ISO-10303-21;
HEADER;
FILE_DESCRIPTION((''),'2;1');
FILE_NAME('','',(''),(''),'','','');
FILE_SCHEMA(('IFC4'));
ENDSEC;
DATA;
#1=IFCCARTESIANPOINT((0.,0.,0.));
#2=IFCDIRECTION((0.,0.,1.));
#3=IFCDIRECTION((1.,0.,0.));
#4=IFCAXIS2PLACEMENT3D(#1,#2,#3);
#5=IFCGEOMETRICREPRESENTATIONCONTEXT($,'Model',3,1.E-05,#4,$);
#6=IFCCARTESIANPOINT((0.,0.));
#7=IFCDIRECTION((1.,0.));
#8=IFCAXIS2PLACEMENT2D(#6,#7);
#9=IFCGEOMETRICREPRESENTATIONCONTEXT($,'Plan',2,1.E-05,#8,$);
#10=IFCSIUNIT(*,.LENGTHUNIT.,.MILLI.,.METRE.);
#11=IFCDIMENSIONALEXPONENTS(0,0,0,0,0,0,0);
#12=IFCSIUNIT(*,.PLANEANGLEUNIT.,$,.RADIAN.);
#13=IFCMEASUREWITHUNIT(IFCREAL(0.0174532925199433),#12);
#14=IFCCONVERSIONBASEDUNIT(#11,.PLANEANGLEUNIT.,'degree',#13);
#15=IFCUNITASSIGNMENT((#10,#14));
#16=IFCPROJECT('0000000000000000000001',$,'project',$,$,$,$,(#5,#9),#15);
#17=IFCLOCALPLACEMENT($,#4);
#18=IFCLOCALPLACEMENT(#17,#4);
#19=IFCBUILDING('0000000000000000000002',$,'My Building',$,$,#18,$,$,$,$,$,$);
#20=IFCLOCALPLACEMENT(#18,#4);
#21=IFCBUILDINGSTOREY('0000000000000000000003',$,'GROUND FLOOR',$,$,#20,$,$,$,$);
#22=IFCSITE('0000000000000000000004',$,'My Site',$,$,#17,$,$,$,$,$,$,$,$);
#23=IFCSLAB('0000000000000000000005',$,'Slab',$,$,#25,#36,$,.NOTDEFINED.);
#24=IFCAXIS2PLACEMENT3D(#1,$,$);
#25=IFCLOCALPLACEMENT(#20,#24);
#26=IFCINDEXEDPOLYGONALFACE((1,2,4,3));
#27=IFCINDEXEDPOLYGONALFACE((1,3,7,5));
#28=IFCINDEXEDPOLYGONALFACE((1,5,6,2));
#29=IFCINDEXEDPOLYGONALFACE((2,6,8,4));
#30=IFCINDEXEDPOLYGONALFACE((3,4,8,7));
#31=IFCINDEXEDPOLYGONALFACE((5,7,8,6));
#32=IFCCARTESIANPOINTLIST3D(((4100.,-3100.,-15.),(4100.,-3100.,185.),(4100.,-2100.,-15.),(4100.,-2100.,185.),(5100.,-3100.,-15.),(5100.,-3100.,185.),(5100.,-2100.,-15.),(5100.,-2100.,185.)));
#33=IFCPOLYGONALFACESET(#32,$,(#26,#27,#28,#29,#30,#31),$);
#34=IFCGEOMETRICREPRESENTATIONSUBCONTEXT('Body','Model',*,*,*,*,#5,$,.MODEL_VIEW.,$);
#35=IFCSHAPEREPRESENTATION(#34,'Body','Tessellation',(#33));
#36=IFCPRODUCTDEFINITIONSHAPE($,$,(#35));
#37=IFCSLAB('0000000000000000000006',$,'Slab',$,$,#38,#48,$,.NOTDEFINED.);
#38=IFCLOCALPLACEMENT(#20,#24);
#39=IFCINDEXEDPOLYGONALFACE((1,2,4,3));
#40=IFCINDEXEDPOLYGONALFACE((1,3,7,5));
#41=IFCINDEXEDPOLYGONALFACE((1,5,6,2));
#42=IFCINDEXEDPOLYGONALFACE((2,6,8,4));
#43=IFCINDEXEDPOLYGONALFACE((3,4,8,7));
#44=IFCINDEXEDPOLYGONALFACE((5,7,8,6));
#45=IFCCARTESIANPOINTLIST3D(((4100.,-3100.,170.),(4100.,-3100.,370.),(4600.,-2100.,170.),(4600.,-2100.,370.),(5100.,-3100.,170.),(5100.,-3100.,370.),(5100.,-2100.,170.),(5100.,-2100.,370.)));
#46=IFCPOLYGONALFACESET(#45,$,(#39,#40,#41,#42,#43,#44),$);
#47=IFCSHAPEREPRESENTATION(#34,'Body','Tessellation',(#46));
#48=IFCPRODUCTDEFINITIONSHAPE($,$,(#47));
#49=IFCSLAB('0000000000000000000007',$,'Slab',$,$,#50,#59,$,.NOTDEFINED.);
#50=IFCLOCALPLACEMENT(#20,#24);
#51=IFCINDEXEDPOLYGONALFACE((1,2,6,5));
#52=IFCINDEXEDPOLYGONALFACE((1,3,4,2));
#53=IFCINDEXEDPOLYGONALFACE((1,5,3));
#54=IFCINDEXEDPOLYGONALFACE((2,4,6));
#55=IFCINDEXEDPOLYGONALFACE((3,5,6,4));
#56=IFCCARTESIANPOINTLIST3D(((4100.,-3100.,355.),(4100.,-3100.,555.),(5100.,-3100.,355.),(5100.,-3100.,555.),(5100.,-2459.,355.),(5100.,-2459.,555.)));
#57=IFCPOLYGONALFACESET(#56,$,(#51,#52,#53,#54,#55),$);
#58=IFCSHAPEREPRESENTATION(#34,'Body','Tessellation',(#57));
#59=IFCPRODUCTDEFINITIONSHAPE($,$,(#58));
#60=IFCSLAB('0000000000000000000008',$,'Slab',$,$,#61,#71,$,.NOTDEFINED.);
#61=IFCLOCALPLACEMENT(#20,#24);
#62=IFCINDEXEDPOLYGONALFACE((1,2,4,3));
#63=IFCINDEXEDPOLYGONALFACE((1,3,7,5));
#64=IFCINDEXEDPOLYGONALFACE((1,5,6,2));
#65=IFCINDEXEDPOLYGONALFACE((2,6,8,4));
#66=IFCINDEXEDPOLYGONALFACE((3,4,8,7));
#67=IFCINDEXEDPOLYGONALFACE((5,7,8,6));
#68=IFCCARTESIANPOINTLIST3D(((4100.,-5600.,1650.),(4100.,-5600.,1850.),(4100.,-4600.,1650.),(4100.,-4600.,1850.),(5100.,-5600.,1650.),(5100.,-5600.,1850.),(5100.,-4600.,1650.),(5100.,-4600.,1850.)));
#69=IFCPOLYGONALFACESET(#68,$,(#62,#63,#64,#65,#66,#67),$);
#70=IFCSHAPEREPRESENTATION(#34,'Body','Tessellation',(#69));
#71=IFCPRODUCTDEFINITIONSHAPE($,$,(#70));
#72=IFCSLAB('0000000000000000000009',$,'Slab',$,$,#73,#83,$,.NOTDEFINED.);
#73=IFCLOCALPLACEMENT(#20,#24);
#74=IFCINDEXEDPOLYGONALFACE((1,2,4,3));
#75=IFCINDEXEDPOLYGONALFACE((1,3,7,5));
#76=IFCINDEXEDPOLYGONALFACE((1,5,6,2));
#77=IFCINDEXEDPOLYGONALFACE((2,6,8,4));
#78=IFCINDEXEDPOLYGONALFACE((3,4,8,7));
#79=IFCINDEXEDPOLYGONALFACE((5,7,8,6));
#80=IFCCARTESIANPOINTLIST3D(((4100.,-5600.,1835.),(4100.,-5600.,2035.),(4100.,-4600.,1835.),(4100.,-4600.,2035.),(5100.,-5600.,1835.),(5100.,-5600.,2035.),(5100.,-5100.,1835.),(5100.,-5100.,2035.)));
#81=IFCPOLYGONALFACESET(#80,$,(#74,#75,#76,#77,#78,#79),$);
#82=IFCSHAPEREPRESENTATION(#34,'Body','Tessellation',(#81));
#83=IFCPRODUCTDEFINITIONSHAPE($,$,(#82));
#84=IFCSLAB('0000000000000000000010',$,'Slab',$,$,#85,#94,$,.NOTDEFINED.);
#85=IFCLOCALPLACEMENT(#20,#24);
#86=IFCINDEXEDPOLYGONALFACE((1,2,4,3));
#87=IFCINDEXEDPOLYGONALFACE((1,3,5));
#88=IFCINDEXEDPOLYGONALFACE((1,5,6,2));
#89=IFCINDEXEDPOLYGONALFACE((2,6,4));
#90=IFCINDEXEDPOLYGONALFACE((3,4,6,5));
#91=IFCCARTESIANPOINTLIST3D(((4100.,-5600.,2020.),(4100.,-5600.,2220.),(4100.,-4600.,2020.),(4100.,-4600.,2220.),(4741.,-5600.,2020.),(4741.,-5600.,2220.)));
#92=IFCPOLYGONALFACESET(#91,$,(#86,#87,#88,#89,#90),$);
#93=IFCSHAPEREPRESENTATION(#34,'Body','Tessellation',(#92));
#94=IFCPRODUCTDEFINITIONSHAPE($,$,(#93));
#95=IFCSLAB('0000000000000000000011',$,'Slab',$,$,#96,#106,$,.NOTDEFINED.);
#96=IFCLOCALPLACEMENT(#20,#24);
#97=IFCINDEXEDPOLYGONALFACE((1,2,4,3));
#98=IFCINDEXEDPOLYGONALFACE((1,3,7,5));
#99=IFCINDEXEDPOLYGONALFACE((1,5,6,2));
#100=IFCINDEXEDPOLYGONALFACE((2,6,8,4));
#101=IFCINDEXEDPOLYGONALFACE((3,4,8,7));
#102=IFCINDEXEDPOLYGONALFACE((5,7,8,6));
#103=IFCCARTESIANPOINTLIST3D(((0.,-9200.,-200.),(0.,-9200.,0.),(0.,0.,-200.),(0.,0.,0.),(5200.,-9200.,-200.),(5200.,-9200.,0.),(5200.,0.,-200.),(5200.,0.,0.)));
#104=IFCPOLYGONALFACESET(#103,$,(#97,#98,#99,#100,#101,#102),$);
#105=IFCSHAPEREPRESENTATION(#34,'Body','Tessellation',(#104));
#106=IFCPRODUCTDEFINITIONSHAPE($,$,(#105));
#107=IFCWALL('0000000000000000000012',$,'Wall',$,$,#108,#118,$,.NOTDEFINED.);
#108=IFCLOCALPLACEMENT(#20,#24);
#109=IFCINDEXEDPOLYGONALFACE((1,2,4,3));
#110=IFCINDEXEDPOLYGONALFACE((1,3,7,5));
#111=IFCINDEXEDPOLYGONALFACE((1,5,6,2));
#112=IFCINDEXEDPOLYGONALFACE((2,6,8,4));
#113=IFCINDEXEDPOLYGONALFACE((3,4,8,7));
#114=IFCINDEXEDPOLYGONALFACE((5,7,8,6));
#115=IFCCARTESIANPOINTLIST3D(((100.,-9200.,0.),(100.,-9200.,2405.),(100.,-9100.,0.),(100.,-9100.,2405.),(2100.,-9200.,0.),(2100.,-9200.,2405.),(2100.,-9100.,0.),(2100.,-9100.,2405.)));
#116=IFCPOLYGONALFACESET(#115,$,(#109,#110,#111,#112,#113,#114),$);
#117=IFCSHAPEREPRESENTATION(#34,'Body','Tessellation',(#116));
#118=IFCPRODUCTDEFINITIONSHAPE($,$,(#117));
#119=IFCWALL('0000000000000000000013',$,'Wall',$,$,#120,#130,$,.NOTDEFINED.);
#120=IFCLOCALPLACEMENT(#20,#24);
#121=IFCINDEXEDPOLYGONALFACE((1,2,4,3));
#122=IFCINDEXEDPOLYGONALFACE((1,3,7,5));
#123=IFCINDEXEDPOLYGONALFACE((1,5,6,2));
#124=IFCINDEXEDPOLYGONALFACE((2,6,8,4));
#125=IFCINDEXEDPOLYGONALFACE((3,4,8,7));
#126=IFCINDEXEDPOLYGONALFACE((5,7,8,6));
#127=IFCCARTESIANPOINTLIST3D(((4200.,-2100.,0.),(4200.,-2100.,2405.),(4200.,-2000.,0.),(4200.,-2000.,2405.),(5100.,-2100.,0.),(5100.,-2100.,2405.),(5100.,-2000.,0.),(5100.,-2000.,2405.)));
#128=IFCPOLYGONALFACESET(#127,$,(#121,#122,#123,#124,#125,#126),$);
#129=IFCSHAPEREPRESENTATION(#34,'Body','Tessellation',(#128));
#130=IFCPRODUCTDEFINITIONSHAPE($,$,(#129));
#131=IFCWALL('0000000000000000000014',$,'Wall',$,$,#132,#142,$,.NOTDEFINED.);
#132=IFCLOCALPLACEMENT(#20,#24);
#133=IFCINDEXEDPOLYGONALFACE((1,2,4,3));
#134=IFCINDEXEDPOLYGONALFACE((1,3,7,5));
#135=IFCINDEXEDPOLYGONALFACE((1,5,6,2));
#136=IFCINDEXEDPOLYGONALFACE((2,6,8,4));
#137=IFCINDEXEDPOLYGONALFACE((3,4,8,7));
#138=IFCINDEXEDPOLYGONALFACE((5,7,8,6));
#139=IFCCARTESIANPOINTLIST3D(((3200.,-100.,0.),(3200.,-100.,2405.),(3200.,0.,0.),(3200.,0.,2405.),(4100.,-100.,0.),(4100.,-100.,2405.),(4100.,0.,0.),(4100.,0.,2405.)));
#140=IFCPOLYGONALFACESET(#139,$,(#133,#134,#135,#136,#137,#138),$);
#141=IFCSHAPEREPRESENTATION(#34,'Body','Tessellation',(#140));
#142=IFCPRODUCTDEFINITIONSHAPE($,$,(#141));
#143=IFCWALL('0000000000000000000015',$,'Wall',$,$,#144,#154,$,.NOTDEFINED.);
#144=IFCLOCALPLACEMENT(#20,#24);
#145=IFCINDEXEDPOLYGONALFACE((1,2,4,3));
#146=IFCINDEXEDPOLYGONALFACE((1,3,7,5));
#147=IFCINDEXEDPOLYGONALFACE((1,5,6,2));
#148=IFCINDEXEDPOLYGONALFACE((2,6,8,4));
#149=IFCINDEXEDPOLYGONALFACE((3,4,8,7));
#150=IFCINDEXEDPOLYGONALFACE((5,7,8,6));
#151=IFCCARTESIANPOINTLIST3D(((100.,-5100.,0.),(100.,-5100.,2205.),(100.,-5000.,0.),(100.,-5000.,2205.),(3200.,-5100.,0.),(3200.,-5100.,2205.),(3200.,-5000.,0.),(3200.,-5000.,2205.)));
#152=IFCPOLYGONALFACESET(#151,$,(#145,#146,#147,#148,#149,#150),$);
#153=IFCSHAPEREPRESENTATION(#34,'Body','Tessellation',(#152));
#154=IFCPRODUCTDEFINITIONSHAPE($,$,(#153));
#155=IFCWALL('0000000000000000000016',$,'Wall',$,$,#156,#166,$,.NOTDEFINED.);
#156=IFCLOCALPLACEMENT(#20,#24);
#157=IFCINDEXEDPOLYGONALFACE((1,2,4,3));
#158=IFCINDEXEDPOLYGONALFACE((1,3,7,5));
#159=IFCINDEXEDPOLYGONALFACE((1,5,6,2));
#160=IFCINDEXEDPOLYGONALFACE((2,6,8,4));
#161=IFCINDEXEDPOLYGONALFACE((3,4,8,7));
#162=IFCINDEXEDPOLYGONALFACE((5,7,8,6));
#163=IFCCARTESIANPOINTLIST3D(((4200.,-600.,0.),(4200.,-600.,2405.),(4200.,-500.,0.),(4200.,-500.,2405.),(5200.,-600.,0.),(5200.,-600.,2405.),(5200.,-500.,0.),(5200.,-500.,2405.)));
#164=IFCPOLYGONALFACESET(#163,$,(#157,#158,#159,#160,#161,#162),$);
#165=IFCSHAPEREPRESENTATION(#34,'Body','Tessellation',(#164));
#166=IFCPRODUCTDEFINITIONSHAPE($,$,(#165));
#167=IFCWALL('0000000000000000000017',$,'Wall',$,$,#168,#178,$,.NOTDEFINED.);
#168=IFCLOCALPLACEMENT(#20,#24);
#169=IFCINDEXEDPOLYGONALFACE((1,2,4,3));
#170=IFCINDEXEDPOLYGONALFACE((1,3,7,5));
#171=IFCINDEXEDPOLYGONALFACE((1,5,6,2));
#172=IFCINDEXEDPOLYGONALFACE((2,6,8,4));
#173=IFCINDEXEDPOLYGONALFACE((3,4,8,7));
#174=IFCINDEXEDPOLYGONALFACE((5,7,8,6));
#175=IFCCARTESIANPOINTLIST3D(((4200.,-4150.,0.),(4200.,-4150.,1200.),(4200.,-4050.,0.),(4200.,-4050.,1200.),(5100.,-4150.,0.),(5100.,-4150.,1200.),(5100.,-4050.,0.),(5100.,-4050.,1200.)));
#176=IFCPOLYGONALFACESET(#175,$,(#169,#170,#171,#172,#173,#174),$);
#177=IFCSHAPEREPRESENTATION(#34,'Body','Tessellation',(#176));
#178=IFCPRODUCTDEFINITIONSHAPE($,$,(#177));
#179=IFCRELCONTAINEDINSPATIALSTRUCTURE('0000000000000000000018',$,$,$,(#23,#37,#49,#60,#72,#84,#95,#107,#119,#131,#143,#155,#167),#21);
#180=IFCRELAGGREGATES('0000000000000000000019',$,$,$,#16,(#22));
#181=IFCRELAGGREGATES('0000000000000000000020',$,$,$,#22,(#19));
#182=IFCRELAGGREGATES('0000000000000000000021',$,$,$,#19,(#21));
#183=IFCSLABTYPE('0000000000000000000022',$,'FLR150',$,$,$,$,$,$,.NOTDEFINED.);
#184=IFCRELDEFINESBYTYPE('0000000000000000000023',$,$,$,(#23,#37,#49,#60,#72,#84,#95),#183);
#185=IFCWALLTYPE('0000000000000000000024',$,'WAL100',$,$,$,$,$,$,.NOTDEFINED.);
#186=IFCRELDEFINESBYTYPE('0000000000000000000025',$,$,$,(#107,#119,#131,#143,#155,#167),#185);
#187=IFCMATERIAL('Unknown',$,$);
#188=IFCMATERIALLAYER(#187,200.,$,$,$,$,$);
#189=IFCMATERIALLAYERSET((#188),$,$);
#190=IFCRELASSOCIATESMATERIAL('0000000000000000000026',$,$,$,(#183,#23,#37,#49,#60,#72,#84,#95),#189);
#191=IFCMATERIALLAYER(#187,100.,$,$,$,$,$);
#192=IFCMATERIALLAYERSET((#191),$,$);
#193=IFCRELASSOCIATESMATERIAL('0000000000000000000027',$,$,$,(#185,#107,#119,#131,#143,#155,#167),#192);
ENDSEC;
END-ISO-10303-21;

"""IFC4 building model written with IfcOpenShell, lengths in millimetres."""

from ifc_helpers import new_model, entity, si_unit, converted_unit, frame, origin_with_axes, origin_2d_with_axis, place, context, subcontext, project, spatial, line, indexed_curve, outline, extrude, material, layer, layer_set, layer_usage, type_object, element, save


model = new_model("IFC4")

# Units and contexts
model_context = context("Model", 3, precision=1e-05, world=origin_with_axes())
plan_context = context("Plan", 2, precision=1e-05, world=origin_2d_with_axis())
body_context = subcontext(model_context, "Body", "Model", "MODEL_VIEW")
ifc_project = project(units=[si_unit("LENGTHUNIT", "METRE", prefix="MILLI"), converted_unit("PLANEANGLEUNIT", "degree", entity("IfcReal", 0.0174532925199433), si_unit("PLANEANGLEUNIT", "RADIAN"), dimensions=[0, 0, 0, 0, 0, 0, 0])], contexts=[model_context, plan_context])

# Site, building, storey
site_placement = place(None, origin_with_axes())
site = spatial("IfcSite", under=ifc_project, at=site_placement, Name="My Site")
building_placement = place(site_placement, origin_with_axes())
building = spatial("IfcBuilding", under=site, at=building_placement, Name="My Building")
storey_placement = place(building_placement, origin_with_axes())
storey = spatial("IfcBuildingStorey", under=building, at=storey_placement, Name="GROUND FLOOR")

# Slabs
ifc_material = material(Name="Unknown")
ifc_layer_1 = layer(ifc_material, 200.0)
ifc_layer_set_1 = layer_set([ifc_layer_1])
ifc_layer_usage_1 = layer_usage(ifc_layer_set_1, "AXIS3", "POSITIVE", 0.0)
slab_type = type_object("IfcSlabType", Name="FLR150", PredefinedType="NOTDEFINED", material=ifc_layer_set_1)
slab_1_placement = place(storey_placement, frame((4100.0, -3100.0, -15.0), z_axis=(0.0, 0.0, 1.0), x_axis=(1.0, 0.0, 0.0)))
element("IfcSlab", 1, at=slab_1_placement, inside=storey, type_object=slab_type, material=ifc_layer_usage_1, Name="Slab", PredefinedType="NOTDEFINED", context=body_context, shape_type="SweptSolid", body=[
    extrude(outline(indexed_curve([(0.0, 0.0), (1000.0, 0.0), (1000.0, 1000.0), (0.0, 1000.0), (0.0, 0.0)])), None, (0.0, 0.0, 1.0), 200.0),
])
ifc_layer_usage_2 = layer_usage(ifc_layer_set_1, "AXIS3", "POSITIVE", 0.0)
slab_2_placement = place(storey_placement, frame((4100.0, -3100.0, 170.0), z_axis=(0.0, 0.0, 1.0), x_axis=(1.0, 0.0, 0.0)))
element("IfcSlab", 2, at=slab_2_placement, inside=storey, type_object=slab_type, material=ifc_layer_usage_2, Name="Slab", PredefinedType="NOTDEFINED", context=body_context, shape_type="SweptSolid", body=[
    extrude(outline(indexed_curve([(0.0, 0.0), (1000.0, 0.0), (1000.0, 1000.0), (500.0, 1000.0)], segments=[line(4, 1), line(1, 2), line(2, 3), line(3, 4)], self_intersect=False)), None, (0.0, 0.0, 1.0), 200.0),
])
ifc_layer_usage_3 = layer_usage(ifc_layer_set_1, "AXIS3", "POSITIVE", 0.0)
slab_3_placement = place(storey_placement, frame((4100.0, -3100.0, 355.0), z_axis=(0.0, 0.0, 1.0), x_axis=(1.0, 0.0, 0.0)))
element("IfcSlab", 3, at=slab_3_placement, inside=storey, type_object=slab_type, material=ifc_layer_usage_3, Name="Slab", PredefinedType="NOTDEFINED", context=body_context, shape_type="SweptSolid", body=[
    extrude(outline(indexed_curve([(0.0, 0.0), (1000.0, 0.0), (1000.0, 641.0)], segments=[line(2, 3), line(3, 1), line(1, 2)], self_intersect=False)), None, (0.0, 0.0, 1.0), 200.0),
])
ifc_layer_usage_4 = layer_usage(ifc_layer_set_1, "AXIS3", "POSITIVE", 0.0)
slab_4_placement = place(storey_placement, frame((4100.0, -4600.0, 1650.0), z_axis=(0.0, 0.0, 1.0), x_axis=(0.0, -1.0, 0.0)))
element("IfcSlab", 4, at=slab_4_placement, inside=storey, type_object=slab_type, material=ifc_layer_usage_4, Name="Slab", PredefinedType="NOTDEFINED", context=body_context, shape_type="SweptSolid", body=[
    extrude(outline(indexed_curve([(0.0, 0.0), (1000.0, 0.0), (1000.0, 1000.0), (0.0, 1000.0), (0.0, 0.0)])), None, (0.0, 0.0, 1.0), 200.0),
])
ifc_layer_usage_5 = layer_usage(ifc_layer_set_1, "AXIS3", "POSITIVE", 0.0)
slab_5_placement = place(storey_placement, frame((4100.0, -4600.0, 1835.0), z_axis=(0.0, 0.0, 1.0), x_axis=(0.0, -1.0, 0.0)))
element("IfcSlab", 5, at=slab_5_placement, inside=storey, type_object=slab_type, material=ifc_layer_usage_5, Name="Slab", PredefinedType="NOTDEFINED", context=body_context, shape_type="SweptSolid", body=[
    extrude(outline(indexed_curve([(0.0, 0.0), (1000.0, 0.0), (1000.0, 1000.0), (500.0, 1000.0)], segments=[line(4, 1), line(1, 2), line(2, 3), line(3, 4)], self_intersect=False)), None, (0.0, 0.0, 1.0), 200.0),
])
ifc_layer_usage_6 = layer_usage(ifc_layer_set_1, "AXIS3", "POSITIVE", 0.0)
slab_6_placement = place(storey_placement, frame((4100.0, -4600.0, 2020.0), z_axis=(0.0, 0.0, 1.0), x_axis=(0.0, -1.0, 0.0)))
element("IfcSlab", 6, at=slab_6_placement, inside=storey, type_object=slab_type, material=ifc_layer_usage_6, Name="Slab", PredefinedType="NOTDEFINED", context=body_context, shape_type="SweptSolid", body=[
    extrude(outline(indexed_curve([(0.0, 0.0), (1000.0, 0.0), (1000.0, 641.0)], segments=[line(2, 3), line(3, 1), line(1, 2)], self_intersect=False)), None, (0.0, 0.0, 1.0), 200.0),
])
ifc_layer_usage_7 = layer_usage(ifc_layer_set_1, "AXIS3", "POSITIVE", 0.0)
slab_7_placement = place(storey_placement, frame((0.0, -9200.0, -200.0), z_axis=(0.0, 0.0, 1.0), x_axis=(1.0, 0.0, 0.0)))
element("IfcSlab", 7, at=slab_7_placement, inside=storey, type_object=slab_type, material=ifc_layer_usage_7, Name="Slab", PredefinedType="NOTDEFINED", context=body_context, shape_type="SweptSolid", body=[
    extrude(outline(indexed_curve([(0.0, 0.0), (5200.0, 0.0), (5200.0, 9200.0), (0.0, 9200.0)], segments=[line(3, 2), line(2, 1), line(1, 4), line(4, 3)], self_intersect=False)), None, (0.0, 0.0, 1.0), 200.0),
])

# Walls
ifc_layer_2 = layer(ifc_material, 100.0)
ifc_layer_set_2 = layer_set([ifc_layer_2])
ifc_layer_usage_8 = layer_usage(ifc_layer_set_2, "AXIS2", "POSITIVE", 0.0)
wall_type = type_object("IfcWallType", Name="WAL100", PredefinedType="NOTDEFINED", material=ifc_layer_set_2)
wall_1_placement = place(storey_placement, frame((100.0, -9200.0, 0.0), z_axis=(0.0, 0.0, 1.0), x_axis=(1.0, -0.000001, 0.0)))
element("IfcWall", 8, at=wall_1_placement, inside=storey, type_object=wall_type, material=ifc_layer_usage_8, Name="Wall", PredefinedType="NOTDEFINED", context=body_context, shape_type="SweptSolid", body=[
    extrude(outline(indexed_curve([(0.0, 0.0), (0.0, 100.0), (2000.0, 100.0), (2000.0, 0.0), (0.0, 0.0)], self_intersect=False)), origin_with_axes(), (0.0, 0.0, 1.0), 2405.0),
])
ifc_layer_usage_9 = layer_usage(ifc_layer_set_2, "AXIS2", "POSITIVE", 0.0)
wall_2_placement = place(storey_placement, frame((5100.0, -2000.0, 0.0), z_axis=(0.0, 0.0, 1.0), x_axis=(-1.0, 0.0, 0.0)))
element("IfcWall", 9, at=wall_2_placement, inside=storey, type_object=wall_type, material=ifc_layer_usage_9, Name="Wall", PredefinedType="NOTDEFINED", context=body_context, shape_type="SweptSolid", body=[
    extrude(outline(indexed_curve([(0.0, 0.0), (0.0, 100.0), (900.0, 100.0), (900.0, 0.0), (0.0, 0.0)], self_intersect=False)), origin_with_axes(), (0.0, 0.0, 1.0), 2405.0),
])
ifc_layer_usage_10 = layer_usage(ifc_layer_set_2, "AXIS2", "POSITIVE", 0.0)
wall_3_placement = place(storey_placement, frame((4100.0, 0.0, 0.0), z_axis=(0.0, 0.0, 1.0), x_axis=(-1.0, 0.0, 0.0)))
element("IfcWall", 10, at=wall_3_placement, inside=storey, type_object=wall_type, material=ifc_layer_usage_10, Name="Wall", PredefinedType="NOTDEFINED", context=body_context, shape_type="SweptSolid", body=[
    extrude(outline(indexed_curve([(0.0, 0.0), (0.0, 100.0), (900.0, 100.0), (900.0, 0.0), (0.0, 0.0)], self_intersect=False)), origin_with_axes(), (0.0, 0.0, 1.0), 2405.0),
])
ifc_layer_usage_11 = layer_usage(ifc_layer_set_2, "AXIS2", "POSITIVE", 0.0)
wall_4_placement = place(storey_placement, frame((3200.0, -5000.0, 0.0), z_axis=(0.0, 0.0, 1.0), x_axis=(-1.0, 0.000001, 0.0)))
element("IfcWall", 11, at=wall_4_placement, inside=storey, type_object=wall_type, material=ifc_layer_usage_11, Name="Wall", PredefinedType="NOTDEFINED", context=body_context, shape_type="SweptSolid", body=[
    extrude(outline(indexed_curve([(0.0, 0.0), (0.0, 100.0), (3100.0, 100.0), (3100.0, 0.0), (0.0, 0.0)], self_intersect=False)), origin_with_axes(), (0.0, 0.0, 1.0), 2205.0),
])
ifc_layer_usage_12 = layer_usage(ifc_layer_set_2, "AXIS2", "POSITIVE", 0.0)
wall_5_placement = place(storey_placement, frame((5200.0, -500.0, 0.0), z_axis=(0.0, 0.0, 1.0), x_axis=(-1.0, 0.0, 0.0)))
element("IfcWall", 12, at=wall_5_placement, inside=storey, type_object=wall_type, material=ifc_layer_usage_12, Name="Wall", PredefinedType="NOTDEFINED", context=body_context, shape_type="SweptSolid", body=[
    extrude(outline(indexed_curve([(0.0, 0.0), (0.0, 100.0), (1000.0, 100.0), (1000.0, 0.0), (0.0, 0.0)], self_intersect=False)), origin_with_axes(), (0.0, 0.0, 1.0), 2405.0),
])
ifc_layer_usage_13 = layer_usage(ifc_layer_set_2, "AXIS2", "POSITIVE", 0.0)
wall_6_placement = place(storey_placement, frame((5100.0, -4050.0, 0.0), z_axis=(0.0, 0.0, 1.0), x_axis=(-1.0, 0.0, 0.0)))
element("IfcWall", 13, at=wall_6_placement, inside=storey, type_object=wall_type, material=ifc_layer_usage_13, Name="Wall", PredefinedType="NOTDEFINED", context=body_context, shape_type="SweptSolid", body=[
    extrude(outline(indexed_curve([(0.0, 0.0), (0.0, 100.0), (900.0, 100.0), (900.0, 0.0), (0.0, 0.0)], self_intersect=False)), origin_with_axes(), (0.0, 0.0, 1.0), 1200.0),
])

save(model, "model.ifc")
